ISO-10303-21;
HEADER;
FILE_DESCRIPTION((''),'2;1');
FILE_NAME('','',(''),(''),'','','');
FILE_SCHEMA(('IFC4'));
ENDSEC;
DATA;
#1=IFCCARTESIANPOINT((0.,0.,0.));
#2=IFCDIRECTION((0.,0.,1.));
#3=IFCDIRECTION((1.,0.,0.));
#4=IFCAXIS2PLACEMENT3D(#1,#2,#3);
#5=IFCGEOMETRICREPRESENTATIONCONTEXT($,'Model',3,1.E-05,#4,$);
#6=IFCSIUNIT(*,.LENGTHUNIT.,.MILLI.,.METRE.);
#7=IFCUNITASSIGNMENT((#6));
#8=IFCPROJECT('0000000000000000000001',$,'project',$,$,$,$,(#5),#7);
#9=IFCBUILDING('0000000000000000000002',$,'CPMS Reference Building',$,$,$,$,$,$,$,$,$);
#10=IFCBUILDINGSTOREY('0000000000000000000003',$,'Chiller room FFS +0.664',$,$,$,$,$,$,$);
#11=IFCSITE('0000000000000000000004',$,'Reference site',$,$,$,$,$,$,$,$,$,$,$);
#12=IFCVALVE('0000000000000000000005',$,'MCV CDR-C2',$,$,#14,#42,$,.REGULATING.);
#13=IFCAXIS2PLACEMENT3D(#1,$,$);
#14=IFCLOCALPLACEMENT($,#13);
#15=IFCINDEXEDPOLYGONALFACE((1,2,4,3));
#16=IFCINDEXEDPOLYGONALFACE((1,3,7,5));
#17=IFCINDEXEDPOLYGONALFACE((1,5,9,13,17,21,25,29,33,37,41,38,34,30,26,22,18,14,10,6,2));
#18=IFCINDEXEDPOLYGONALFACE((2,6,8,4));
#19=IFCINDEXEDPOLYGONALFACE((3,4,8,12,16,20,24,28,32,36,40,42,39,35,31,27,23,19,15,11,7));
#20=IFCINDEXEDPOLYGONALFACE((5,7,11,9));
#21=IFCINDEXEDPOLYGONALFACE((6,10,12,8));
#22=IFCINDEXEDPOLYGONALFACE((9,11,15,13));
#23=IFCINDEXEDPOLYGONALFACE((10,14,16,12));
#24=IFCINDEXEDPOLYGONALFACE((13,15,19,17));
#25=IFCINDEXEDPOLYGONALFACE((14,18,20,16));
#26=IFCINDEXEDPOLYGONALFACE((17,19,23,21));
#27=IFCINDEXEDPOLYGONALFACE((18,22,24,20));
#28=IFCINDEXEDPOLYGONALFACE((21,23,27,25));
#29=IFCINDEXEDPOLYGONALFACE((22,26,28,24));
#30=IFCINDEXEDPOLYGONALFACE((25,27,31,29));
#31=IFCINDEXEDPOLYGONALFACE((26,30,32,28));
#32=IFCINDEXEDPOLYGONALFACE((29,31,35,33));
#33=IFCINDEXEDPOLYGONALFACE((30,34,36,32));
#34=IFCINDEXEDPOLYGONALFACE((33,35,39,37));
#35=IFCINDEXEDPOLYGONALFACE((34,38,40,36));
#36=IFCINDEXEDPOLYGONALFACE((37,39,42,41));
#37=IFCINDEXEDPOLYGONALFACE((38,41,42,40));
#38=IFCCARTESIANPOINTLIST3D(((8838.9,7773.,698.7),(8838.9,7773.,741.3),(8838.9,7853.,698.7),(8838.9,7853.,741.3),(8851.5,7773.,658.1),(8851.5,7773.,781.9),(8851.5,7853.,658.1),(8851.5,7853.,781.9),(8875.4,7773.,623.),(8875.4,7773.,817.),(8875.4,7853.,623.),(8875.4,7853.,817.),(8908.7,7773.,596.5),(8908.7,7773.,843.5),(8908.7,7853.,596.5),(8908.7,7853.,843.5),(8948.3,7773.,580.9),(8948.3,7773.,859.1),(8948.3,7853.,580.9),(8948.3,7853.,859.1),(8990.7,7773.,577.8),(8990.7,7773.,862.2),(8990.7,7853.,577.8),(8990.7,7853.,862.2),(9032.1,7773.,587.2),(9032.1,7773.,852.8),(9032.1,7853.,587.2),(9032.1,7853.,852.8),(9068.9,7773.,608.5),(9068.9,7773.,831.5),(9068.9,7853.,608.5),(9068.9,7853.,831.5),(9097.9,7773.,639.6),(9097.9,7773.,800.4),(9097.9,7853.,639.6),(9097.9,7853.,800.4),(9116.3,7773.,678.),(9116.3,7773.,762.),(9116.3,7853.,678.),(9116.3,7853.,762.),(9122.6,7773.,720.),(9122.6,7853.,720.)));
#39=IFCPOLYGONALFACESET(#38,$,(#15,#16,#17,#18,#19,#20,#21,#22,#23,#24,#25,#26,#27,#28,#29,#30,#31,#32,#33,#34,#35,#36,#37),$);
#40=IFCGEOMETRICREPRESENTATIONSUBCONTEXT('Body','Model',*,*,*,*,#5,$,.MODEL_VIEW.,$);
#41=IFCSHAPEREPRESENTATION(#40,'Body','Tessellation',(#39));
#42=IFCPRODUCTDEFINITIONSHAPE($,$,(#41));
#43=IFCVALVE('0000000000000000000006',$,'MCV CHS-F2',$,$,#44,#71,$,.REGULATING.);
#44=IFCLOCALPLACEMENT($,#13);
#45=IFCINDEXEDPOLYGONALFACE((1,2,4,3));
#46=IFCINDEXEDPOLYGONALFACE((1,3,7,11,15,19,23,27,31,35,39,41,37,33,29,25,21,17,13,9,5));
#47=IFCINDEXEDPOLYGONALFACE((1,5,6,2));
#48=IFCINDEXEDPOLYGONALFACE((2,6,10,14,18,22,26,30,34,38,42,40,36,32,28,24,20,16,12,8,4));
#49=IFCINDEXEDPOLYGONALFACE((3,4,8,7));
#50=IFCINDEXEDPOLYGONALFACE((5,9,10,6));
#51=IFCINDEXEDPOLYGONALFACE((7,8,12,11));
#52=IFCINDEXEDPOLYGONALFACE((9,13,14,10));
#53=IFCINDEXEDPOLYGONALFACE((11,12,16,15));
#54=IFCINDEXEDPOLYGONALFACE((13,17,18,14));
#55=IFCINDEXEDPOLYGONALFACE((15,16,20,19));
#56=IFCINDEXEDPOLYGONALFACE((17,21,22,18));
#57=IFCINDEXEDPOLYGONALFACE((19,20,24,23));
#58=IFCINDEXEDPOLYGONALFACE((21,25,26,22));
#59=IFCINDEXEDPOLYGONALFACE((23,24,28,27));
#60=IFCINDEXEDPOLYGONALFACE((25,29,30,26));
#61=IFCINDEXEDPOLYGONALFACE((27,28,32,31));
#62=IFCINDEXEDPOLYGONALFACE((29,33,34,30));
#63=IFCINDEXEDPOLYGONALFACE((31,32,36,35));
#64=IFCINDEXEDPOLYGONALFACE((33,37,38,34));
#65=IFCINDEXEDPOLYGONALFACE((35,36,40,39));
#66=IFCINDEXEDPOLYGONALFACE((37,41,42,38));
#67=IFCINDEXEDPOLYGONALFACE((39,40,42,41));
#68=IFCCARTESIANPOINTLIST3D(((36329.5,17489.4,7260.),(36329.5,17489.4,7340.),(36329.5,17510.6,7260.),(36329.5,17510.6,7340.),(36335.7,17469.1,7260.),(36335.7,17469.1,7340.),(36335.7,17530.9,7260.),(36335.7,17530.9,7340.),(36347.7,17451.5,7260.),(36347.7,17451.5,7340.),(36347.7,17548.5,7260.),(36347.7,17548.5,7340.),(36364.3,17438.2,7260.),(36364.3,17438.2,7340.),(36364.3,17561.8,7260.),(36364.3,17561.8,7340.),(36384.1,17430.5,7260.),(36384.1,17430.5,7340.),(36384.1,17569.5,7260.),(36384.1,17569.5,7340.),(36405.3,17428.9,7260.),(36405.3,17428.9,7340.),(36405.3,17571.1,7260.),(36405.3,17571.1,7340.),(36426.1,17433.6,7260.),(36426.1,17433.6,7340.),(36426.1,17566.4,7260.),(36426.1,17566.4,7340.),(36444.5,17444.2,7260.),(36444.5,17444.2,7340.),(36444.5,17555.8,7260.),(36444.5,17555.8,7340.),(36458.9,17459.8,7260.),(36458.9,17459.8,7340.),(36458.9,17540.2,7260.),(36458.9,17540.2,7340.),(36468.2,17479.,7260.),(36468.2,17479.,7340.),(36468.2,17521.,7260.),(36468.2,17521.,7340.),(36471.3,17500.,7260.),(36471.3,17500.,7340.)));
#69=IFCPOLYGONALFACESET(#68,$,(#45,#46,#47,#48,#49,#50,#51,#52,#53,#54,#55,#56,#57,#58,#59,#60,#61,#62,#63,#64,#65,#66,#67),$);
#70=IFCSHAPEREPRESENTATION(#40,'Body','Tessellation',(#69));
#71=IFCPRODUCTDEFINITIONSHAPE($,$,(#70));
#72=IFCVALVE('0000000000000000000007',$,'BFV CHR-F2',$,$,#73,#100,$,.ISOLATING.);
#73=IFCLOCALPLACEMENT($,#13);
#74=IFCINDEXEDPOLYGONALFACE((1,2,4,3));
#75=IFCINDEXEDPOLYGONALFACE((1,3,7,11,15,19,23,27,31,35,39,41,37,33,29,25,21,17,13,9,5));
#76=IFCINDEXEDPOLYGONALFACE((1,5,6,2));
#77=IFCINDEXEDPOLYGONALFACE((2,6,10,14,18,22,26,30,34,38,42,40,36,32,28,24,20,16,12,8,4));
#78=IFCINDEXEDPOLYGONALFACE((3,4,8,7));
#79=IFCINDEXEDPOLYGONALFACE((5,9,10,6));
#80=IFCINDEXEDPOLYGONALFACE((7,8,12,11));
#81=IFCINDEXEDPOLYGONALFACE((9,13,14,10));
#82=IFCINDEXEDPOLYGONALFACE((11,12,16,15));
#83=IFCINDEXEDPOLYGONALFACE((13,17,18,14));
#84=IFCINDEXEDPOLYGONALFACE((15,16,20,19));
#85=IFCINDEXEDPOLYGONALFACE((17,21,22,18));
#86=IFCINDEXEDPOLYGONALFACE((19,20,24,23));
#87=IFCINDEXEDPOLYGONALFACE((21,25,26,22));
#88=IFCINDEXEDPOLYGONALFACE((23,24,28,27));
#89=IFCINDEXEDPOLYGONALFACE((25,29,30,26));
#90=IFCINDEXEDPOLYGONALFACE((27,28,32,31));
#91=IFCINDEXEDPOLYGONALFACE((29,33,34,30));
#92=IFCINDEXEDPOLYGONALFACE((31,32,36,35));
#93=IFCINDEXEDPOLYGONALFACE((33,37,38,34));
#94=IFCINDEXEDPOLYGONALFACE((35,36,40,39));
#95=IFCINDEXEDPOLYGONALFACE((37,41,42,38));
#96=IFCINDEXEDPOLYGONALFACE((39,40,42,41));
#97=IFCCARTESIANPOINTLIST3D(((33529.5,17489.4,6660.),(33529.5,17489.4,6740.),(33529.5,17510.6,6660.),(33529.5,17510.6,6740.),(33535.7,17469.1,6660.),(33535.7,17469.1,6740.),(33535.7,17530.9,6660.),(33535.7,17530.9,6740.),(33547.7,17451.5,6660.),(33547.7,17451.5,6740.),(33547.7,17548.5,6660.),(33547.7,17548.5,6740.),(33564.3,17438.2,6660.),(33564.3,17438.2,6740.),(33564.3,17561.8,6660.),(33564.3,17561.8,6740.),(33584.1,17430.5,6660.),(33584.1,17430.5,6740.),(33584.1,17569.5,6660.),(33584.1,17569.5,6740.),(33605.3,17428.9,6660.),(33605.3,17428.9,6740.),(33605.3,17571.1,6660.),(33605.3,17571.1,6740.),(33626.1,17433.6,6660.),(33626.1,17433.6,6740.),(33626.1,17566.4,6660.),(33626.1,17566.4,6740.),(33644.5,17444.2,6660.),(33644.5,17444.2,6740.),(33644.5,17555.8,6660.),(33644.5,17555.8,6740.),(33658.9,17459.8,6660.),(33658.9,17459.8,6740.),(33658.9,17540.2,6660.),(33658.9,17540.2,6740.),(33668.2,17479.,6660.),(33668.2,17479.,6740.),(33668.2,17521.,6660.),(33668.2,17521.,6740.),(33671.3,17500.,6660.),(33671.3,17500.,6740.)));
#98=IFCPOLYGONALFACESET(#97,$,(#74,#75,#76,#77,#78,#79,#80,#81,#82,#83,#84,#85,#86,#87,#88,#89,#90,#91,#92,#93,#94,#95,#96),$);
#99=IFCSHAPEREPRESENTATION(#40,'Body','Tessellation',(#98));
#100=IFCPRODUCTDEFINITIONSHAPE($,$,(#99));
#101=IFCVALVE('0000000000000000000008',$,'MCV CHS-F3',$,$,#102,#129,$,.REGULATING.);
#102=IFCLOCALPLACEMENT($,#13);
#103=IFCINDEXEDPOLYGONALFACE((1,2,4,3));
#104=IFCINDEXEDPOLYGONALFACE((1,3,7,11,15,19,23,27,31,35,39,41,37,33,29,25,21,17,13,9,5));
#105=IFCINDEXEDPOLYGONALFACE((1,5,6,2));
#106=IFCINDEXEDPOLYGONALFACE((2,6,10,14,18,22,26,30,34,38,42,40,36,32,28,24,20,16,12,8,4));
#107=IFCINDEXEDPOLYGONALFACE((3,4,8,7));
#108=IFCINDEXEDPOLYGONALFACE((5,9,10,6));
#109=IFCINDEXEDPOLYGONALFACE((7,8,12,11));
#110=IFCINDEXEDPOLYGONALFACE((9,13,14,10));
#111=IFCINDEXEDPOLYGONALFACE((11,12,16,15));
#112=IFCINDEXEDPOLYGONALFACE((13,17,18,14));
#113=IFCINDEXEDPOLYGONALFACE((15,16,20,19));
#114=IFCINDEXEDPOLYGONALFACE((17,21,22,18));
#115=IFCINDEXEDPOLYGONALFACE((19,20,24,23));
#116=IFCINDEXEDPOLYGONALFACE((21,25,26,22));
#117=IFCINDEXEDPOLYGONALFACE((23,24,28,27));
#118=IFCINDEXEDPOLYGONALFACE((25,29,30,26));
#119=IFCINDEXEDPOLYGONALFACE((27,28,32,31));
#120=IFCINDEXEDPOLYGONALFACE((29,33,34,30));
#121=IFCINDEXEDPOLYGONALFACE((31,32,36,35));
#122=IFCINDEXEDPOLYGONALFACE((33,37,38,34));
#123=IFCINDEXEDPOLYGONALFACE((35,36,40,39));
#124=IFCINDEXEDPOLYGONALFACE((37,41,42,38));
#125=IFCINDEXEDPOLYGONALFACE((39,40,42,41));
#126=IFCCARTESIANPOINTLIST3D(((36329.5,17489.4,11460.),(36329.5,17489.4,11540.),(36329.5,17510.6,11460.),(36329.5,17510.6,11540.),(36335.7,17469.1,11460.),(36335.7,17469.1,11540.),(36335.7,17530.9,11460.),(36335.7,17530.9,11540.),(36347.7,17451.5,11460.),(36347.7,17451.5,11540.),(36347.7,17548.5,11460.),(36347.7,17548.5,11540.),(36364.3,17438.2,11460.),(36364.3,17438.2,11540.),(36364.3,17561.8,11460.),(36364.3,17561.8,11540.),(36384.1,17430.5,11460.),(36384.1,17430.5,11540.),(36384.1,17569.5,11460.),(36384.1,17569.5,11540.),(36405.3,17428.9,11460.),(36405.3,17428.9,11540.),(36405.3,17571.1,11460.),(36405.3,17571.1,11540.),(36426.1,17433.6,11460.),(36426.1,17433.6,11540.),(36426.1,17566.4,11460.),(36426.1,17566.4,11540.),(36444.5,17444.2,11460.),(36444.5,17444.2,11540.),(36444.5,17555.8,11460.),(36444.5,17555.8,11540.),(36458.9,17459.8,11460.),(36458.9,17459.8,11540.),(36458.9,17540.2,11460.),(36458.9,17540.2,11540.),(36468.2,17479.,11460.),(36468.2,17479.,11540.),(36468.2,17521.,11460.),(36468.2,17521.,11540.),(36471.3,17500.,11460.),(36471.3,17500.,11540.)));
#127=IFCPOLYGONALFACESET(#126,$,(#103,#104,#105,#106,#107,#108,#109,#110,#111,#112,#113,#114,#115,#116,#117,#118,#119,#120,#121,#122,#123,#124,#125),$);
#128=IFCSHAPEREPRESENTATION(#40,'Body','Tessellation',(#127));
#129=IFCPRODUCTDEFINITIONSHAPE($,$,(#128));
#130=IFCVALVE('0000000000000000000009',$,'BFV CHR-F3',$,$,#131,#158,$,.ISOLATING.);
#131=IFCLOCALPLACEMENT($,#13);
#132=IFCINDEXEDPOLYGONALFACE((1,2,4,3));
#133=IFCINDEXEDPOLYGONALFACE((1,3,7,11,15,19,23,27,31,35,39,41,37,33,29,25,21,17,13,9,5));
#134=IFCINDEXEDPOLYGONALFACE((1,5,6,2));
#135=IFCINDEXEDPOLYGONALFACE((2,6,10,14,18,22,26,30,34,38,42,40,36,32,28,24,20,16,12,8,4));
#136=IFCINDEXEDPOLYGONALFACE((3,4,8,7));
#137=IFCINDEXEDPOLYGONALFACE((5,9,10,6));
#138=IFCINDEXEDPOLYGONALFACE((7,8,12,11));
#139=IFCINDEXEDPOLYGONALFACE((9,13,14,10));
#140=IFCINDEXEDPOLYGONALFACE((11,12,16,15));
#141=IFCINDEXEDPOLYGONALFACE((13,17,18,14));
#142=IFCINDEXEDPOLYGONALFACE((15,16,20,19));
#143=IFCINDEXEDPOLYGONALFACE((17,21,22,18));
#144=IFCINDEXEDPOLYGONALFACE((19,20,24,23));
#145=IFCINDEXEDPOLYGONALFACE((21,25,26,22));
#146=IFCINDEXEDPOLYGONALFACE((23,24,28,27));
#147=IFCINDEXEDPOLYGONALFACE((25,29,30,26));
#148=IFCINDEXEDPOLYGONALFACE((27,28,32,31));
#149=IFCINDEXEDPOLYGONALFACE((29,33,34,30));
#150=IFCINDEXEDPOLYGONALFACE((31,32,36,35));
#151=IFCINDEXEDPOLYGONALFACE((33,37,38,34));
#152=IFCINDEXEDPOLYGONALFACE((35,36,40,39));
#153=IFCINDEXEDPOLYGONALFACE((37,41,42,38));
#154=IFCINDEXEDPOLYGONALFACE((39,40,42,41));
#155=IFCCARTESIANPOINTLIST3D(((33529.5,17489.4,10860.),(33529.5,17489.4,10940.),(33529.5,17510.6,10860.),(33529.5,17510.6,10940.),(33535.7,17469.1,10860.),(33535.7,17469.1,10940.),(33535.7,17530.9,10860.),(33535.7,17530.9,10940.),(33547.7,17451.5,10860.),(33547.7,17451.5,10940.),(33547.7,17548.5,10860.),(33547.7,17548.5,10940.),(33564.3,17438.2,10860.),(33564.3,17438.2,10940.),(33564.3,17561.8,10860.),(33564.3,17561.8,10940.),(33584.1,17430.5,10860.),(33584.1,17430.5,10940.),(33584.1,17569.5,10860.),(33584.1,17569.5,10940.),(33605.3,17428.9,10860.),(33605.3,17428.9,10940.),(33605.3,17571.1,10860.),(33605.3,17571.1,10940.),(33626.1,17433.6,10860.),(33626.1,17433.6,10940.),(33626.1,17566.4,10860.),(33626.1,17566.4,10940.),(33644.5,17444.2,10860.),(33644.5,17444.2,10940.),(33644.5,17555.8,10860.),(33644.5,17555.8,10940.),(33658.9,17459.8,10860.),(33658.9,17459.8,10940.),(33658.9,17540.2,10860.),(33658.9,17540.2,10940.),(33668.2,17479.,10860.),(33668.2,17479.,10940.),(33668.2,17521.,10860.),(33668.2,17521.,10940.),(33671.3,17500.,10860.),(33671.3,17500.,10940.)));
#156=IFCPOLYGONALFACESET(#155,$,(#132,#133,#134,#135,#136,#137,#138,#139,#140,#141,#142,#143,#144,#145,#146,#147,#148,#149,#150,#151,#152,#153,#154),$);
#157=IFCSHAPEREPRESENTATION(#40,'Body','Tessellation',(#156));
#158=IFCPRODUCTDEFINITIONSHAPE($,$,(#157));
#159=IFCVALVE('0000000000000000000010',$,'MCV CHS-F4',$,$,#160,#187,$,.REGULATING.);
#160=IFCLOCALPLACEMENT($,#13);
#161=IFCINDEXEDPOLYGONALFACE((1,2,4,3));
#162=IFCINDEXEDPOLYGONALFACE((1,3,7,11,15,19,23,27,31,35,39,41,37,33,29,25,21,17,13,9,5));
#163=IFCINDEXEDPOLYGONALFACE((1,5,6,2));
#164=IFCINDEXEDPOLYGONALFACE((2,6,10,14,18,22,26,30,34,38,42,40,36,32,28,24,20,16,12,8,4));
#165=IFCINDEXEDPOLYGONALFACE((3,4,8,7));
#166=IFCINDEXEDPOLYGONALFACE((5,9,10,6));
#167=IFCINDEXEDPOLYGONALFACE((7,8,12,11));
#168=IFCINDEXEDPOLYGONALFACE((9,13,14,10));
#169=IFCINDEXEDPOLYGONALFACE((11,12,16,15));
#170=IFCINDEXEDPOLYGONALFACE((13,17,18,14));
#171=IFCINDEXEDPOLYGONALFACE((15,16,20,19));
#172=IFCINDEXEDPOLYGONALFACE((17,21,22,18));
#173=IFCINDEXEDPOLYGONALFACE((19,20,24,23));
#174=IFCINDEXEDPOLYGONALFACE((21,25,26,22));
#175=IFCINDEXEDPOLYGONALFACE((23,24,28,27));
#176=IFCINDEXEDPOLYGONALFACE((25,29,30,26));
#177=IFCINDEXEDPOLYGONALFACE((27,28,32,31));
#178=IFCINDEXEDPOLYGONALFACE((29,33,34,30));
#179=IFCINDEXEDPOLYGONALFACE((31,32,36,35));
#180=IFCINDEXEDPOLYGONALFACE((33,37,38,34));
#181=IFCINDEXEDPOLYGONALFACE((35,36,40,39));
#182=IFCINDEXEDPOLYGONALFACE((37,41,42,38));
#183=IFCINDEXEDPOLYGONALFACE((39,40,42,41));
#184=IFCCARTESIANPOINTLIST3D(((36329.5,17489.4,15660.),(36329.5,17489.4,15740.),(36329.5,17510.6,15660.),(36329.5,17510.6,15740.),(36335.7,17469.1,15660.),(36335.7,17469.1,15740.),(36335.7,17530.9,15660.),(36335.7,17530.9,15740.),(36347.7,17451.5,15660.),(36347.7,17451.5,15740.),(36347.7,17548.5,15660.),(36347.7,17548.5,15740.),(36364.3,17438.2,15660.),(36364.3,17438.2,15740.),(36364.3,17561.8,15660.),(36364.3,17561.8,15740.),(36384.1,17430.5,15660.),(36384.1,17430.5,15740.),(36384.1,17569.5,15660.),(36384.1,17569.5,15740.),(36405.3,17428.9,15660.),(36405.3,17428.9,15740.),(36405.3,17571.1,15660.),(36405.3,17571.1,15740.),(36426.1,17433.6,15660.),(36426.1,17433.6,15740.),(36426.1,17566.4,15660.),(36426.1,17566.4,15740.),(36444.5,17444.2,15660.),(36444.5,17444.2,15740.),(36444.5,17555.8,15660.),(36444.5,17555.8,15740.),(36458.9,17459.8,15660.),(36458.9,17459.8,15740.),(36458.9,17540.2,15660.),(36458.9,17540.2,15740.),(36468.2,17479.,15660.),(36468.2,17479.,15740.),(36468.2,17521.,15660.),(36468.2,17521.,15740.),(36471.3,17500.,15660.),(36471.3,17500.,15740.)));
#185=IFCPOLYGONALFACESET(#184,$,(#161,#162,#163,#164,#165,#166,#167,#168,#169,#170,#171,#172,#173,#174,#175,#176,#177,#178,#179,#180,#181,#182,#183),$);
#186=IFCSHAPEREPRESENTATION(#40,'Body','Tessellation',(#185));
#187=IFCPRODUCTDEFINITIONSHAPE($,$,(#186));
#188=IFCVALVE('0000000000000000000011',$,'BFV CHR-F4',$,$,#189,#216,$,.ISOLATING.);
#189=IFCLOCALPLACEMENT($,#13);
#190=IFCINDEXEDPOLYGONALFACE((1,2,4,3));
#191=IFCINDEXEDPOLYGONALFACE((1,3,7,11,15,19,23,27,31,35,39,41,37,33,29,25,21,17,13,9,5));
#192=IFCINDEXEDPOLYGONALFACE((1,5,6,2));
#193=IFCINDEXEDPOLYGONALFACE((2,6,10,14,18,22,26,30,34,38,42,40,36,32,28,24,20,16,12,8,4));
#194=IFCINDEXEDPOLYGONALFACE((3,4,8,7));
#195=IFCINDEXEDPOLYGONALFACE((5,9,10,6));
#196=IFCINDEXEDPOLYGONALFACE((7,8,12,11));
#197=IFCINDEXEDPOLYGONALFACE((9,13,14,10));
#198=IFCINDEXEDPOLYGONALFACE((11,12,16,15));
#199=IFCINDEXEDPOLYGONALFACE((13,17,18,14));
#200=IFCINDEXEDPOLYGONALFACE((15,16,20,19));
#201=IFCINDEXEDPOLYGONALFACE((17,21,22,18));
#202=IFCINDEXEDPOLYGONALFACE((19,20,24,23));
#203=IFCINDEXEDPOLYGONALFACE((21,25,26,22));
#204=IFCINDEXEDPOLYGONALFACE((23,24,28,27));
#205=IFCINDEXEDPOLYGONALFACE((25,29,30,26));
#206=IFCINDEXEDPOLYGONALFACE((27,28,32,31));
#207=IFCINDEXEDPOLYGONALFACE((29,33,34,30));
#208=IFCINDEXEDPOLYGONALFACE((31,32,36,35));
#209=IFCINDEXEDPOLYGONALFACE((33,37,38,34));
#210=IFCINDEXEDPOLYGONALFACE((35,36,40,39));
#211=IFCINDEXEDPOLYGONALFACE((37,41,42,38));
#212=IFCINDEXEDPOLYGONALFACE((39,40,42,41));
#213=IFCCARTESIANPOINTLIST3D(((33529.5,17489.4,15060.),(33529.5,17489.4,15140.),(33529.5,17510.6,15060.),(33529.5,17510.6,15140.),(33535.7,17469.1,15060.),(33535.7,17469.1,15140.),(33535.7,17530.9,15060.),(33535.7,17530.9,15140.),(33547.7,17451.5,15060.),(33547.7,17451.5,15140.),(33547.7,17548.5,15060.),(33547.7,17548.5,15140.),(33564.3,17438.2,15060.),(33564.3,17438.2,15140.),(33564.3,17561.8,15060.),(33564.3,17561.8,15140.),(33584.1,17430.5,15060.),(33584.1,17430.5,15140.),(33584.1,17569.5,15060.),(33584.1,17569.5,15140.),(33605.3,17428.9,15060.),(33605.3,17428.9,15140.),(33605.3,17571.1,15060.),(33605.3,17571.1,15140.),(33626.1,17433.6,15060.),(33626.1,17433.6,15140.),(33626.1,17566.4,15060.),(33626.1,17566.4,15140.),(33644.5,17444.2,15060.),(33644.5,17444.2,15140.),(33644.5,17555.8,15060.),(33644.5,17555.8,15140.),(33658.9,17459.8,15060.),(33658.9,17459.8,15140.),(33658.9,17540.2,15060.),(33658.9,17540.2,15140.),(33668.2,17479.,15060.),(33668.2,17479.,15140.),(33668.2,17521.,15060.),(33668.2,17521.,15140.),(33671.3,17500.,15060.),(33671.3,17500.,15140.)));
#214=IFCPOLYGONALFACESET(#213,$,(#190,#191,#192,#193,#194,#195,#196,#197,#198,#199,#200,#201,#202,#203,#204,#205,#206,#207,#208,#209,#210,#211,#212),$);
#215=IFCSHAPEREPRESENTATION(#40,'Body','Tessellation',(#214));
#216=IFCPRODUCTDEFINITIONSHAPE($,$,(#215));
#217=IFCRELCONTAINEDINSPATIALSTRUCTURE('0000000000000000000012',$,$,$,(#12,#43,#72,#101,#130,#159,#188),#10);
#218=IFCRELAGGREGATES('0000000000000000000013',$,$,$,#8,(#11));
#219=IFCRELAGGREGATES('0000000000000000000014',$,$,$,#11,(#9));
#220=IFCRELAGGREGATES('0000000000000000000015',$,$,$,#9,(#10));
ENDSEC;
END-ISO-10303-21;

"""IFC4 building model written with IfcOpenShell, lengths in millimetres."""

from ifc_helpers import new_model, si_unit, frame, origin_with_axes, origin_2d, place, context, subcontext, project, spatial, circle_curve, outline, extrude, element, save


model = new_model("IFC4")

# Units and contexts
model_context = context("Model", 3, precision=1e-05, world=origin_with_axes())
body_context = subcontext(model_context, "Body", "Model", "MODEL_VIEW")
ifc_project = project(units=[si_unit("LENGTHUNIT", "METRE", prefix="MILLI")], contexts=[model_context])

# Site, building, storey
site = spatial("IfcSite", under=ifc_project, Name="Reference site")
building = spatial("IfcBuilding", under=site, Name="CPMS Reference Building")
storey = spatial("IfcBuildingStorey", under=building, Name="Chiller room FFS +0.664")

# Valves
valve_1_placement = place(None, origin_with_axes())
element("IfcValve", 1, at=valve_1_placement, inside=storey, Name="MCV CDR-C2", PredefinedType="REGULATING", context=body_context, shape_type="SweptSolid", body=[
    extrude(outline(circle_curve(origin_2d(), 142.6)), frame((8980.0, 7853.0, 720.0), z_axis=(0.0, -1.0, 0.0), x_axis=(1.0, 0.0, 0.0)), (0.0, 0.0, 1.0), 80.0),
])
valve_2_placement = place(None, origin_with_axes())
element("IfcValve", 2, at=valve_2_placement, inside=storey, Name="MCV CHS-F2", PredefinedType="REGULATING", context=body_context, shape_type="SweptSolid", body=[
    extrude(outline(circle_curve(origin_2d(), 71.3)), frame((36400.0, 17500.0, 7340.0), z_axis=(0.0, 0.0, -1.0), x_axis=(1.0, 0.0, 0.0)), (0.0, 0.0, 1.0), 80.0),
])
valve_3_placement = place(None, origin_with_axes())
element("IfcValve", 3, at=valve_3_placement, inside=storey, Name="BFV CHR-F2", PredefinedType="ISOLATING", context=body_context, shape_type="SweptSolid", body=[
    extrude(outline(circle_curve(origin_2d(), 71.3)), frame((33600.0, 17500.0, 6660.0), z_axis=(0.0, 0.0, 1.0), x_axis=(1.0, 0.0, 0.0)), (0.0, 0.0, 1.0), 80.0),
])
valve_4_placement = place(None, origin_with_axes())
element("IfcValve", 4, at=valve_4_placement, inside=storey, Name="MCV CHS-F3", PredefinedType="REGULATING", context=body_context, shape_type="SweptSolid", body=[
    extrude(outline(circle_curve(origin_2d(), 71.3)), frame((36400.0, 17500.0, 11540.0), z_axis=(0.0, 0.0, -1.0), x_axis=(1.0, 0.0, 0.0)), (0.0, 0.0, 1.0), 80.0),
])
valve_5_placement = place(None, origin_with_axes())
element("IfcValve", 5, at=valve_5_placement, inside=storey, Name="BFV CHR-F3", PredefinedType="ISOLATING", context=body_context, shape_type="SweptSolid", body=[
    extrude(outline(circle_curve(origin_2d(), 71.3)), frame((33600.0, 17500.0, 10860.0), z_axis=(0.0, 0.0, 1.0), x_axis=(1.0, 0.0, 0.0)), (0.0, 0.0, 1.0), 80.0),
])
valve_6_placement = place(None, origin_with_axes())
element("IfcValve", 6, at=valve_6_placement, inside=storey, Name="MCV CHS-F4", PredefinedType="REGULATING", context=body_context, shape_type="SweptSolid", body=[
    extrude(outline(circle_curve(origin_2d(), 71.3)), frame((36400.0, 17500.0, 15740.0), z_axis=(0.0, 0.0, -1.0), x_axis=(1.0, 0.0, 0.0)), (0.0, 0.0, 1.0), 80.0),
])
valve_7_placement = place(None, origin_with_axes())
element("IfcValve", 7, at=valve_7_placement, inside=storey, Name="BFV CHR-F4", PredefinedType="ISOLATING", context=body_context, shape_type="SweptSolid", body=[
    extrude(outline(circle_curve(origin_2d(), 71.3)), frame((33600.0, 17500.0, 15060.0), z_axis=(0.0, 0.0, 1.0), x_axis=(1.0, 0.0, 0.0)), (0.0, 0.0, 1.0), 80.0),
])

save(model, "model.ifc")
